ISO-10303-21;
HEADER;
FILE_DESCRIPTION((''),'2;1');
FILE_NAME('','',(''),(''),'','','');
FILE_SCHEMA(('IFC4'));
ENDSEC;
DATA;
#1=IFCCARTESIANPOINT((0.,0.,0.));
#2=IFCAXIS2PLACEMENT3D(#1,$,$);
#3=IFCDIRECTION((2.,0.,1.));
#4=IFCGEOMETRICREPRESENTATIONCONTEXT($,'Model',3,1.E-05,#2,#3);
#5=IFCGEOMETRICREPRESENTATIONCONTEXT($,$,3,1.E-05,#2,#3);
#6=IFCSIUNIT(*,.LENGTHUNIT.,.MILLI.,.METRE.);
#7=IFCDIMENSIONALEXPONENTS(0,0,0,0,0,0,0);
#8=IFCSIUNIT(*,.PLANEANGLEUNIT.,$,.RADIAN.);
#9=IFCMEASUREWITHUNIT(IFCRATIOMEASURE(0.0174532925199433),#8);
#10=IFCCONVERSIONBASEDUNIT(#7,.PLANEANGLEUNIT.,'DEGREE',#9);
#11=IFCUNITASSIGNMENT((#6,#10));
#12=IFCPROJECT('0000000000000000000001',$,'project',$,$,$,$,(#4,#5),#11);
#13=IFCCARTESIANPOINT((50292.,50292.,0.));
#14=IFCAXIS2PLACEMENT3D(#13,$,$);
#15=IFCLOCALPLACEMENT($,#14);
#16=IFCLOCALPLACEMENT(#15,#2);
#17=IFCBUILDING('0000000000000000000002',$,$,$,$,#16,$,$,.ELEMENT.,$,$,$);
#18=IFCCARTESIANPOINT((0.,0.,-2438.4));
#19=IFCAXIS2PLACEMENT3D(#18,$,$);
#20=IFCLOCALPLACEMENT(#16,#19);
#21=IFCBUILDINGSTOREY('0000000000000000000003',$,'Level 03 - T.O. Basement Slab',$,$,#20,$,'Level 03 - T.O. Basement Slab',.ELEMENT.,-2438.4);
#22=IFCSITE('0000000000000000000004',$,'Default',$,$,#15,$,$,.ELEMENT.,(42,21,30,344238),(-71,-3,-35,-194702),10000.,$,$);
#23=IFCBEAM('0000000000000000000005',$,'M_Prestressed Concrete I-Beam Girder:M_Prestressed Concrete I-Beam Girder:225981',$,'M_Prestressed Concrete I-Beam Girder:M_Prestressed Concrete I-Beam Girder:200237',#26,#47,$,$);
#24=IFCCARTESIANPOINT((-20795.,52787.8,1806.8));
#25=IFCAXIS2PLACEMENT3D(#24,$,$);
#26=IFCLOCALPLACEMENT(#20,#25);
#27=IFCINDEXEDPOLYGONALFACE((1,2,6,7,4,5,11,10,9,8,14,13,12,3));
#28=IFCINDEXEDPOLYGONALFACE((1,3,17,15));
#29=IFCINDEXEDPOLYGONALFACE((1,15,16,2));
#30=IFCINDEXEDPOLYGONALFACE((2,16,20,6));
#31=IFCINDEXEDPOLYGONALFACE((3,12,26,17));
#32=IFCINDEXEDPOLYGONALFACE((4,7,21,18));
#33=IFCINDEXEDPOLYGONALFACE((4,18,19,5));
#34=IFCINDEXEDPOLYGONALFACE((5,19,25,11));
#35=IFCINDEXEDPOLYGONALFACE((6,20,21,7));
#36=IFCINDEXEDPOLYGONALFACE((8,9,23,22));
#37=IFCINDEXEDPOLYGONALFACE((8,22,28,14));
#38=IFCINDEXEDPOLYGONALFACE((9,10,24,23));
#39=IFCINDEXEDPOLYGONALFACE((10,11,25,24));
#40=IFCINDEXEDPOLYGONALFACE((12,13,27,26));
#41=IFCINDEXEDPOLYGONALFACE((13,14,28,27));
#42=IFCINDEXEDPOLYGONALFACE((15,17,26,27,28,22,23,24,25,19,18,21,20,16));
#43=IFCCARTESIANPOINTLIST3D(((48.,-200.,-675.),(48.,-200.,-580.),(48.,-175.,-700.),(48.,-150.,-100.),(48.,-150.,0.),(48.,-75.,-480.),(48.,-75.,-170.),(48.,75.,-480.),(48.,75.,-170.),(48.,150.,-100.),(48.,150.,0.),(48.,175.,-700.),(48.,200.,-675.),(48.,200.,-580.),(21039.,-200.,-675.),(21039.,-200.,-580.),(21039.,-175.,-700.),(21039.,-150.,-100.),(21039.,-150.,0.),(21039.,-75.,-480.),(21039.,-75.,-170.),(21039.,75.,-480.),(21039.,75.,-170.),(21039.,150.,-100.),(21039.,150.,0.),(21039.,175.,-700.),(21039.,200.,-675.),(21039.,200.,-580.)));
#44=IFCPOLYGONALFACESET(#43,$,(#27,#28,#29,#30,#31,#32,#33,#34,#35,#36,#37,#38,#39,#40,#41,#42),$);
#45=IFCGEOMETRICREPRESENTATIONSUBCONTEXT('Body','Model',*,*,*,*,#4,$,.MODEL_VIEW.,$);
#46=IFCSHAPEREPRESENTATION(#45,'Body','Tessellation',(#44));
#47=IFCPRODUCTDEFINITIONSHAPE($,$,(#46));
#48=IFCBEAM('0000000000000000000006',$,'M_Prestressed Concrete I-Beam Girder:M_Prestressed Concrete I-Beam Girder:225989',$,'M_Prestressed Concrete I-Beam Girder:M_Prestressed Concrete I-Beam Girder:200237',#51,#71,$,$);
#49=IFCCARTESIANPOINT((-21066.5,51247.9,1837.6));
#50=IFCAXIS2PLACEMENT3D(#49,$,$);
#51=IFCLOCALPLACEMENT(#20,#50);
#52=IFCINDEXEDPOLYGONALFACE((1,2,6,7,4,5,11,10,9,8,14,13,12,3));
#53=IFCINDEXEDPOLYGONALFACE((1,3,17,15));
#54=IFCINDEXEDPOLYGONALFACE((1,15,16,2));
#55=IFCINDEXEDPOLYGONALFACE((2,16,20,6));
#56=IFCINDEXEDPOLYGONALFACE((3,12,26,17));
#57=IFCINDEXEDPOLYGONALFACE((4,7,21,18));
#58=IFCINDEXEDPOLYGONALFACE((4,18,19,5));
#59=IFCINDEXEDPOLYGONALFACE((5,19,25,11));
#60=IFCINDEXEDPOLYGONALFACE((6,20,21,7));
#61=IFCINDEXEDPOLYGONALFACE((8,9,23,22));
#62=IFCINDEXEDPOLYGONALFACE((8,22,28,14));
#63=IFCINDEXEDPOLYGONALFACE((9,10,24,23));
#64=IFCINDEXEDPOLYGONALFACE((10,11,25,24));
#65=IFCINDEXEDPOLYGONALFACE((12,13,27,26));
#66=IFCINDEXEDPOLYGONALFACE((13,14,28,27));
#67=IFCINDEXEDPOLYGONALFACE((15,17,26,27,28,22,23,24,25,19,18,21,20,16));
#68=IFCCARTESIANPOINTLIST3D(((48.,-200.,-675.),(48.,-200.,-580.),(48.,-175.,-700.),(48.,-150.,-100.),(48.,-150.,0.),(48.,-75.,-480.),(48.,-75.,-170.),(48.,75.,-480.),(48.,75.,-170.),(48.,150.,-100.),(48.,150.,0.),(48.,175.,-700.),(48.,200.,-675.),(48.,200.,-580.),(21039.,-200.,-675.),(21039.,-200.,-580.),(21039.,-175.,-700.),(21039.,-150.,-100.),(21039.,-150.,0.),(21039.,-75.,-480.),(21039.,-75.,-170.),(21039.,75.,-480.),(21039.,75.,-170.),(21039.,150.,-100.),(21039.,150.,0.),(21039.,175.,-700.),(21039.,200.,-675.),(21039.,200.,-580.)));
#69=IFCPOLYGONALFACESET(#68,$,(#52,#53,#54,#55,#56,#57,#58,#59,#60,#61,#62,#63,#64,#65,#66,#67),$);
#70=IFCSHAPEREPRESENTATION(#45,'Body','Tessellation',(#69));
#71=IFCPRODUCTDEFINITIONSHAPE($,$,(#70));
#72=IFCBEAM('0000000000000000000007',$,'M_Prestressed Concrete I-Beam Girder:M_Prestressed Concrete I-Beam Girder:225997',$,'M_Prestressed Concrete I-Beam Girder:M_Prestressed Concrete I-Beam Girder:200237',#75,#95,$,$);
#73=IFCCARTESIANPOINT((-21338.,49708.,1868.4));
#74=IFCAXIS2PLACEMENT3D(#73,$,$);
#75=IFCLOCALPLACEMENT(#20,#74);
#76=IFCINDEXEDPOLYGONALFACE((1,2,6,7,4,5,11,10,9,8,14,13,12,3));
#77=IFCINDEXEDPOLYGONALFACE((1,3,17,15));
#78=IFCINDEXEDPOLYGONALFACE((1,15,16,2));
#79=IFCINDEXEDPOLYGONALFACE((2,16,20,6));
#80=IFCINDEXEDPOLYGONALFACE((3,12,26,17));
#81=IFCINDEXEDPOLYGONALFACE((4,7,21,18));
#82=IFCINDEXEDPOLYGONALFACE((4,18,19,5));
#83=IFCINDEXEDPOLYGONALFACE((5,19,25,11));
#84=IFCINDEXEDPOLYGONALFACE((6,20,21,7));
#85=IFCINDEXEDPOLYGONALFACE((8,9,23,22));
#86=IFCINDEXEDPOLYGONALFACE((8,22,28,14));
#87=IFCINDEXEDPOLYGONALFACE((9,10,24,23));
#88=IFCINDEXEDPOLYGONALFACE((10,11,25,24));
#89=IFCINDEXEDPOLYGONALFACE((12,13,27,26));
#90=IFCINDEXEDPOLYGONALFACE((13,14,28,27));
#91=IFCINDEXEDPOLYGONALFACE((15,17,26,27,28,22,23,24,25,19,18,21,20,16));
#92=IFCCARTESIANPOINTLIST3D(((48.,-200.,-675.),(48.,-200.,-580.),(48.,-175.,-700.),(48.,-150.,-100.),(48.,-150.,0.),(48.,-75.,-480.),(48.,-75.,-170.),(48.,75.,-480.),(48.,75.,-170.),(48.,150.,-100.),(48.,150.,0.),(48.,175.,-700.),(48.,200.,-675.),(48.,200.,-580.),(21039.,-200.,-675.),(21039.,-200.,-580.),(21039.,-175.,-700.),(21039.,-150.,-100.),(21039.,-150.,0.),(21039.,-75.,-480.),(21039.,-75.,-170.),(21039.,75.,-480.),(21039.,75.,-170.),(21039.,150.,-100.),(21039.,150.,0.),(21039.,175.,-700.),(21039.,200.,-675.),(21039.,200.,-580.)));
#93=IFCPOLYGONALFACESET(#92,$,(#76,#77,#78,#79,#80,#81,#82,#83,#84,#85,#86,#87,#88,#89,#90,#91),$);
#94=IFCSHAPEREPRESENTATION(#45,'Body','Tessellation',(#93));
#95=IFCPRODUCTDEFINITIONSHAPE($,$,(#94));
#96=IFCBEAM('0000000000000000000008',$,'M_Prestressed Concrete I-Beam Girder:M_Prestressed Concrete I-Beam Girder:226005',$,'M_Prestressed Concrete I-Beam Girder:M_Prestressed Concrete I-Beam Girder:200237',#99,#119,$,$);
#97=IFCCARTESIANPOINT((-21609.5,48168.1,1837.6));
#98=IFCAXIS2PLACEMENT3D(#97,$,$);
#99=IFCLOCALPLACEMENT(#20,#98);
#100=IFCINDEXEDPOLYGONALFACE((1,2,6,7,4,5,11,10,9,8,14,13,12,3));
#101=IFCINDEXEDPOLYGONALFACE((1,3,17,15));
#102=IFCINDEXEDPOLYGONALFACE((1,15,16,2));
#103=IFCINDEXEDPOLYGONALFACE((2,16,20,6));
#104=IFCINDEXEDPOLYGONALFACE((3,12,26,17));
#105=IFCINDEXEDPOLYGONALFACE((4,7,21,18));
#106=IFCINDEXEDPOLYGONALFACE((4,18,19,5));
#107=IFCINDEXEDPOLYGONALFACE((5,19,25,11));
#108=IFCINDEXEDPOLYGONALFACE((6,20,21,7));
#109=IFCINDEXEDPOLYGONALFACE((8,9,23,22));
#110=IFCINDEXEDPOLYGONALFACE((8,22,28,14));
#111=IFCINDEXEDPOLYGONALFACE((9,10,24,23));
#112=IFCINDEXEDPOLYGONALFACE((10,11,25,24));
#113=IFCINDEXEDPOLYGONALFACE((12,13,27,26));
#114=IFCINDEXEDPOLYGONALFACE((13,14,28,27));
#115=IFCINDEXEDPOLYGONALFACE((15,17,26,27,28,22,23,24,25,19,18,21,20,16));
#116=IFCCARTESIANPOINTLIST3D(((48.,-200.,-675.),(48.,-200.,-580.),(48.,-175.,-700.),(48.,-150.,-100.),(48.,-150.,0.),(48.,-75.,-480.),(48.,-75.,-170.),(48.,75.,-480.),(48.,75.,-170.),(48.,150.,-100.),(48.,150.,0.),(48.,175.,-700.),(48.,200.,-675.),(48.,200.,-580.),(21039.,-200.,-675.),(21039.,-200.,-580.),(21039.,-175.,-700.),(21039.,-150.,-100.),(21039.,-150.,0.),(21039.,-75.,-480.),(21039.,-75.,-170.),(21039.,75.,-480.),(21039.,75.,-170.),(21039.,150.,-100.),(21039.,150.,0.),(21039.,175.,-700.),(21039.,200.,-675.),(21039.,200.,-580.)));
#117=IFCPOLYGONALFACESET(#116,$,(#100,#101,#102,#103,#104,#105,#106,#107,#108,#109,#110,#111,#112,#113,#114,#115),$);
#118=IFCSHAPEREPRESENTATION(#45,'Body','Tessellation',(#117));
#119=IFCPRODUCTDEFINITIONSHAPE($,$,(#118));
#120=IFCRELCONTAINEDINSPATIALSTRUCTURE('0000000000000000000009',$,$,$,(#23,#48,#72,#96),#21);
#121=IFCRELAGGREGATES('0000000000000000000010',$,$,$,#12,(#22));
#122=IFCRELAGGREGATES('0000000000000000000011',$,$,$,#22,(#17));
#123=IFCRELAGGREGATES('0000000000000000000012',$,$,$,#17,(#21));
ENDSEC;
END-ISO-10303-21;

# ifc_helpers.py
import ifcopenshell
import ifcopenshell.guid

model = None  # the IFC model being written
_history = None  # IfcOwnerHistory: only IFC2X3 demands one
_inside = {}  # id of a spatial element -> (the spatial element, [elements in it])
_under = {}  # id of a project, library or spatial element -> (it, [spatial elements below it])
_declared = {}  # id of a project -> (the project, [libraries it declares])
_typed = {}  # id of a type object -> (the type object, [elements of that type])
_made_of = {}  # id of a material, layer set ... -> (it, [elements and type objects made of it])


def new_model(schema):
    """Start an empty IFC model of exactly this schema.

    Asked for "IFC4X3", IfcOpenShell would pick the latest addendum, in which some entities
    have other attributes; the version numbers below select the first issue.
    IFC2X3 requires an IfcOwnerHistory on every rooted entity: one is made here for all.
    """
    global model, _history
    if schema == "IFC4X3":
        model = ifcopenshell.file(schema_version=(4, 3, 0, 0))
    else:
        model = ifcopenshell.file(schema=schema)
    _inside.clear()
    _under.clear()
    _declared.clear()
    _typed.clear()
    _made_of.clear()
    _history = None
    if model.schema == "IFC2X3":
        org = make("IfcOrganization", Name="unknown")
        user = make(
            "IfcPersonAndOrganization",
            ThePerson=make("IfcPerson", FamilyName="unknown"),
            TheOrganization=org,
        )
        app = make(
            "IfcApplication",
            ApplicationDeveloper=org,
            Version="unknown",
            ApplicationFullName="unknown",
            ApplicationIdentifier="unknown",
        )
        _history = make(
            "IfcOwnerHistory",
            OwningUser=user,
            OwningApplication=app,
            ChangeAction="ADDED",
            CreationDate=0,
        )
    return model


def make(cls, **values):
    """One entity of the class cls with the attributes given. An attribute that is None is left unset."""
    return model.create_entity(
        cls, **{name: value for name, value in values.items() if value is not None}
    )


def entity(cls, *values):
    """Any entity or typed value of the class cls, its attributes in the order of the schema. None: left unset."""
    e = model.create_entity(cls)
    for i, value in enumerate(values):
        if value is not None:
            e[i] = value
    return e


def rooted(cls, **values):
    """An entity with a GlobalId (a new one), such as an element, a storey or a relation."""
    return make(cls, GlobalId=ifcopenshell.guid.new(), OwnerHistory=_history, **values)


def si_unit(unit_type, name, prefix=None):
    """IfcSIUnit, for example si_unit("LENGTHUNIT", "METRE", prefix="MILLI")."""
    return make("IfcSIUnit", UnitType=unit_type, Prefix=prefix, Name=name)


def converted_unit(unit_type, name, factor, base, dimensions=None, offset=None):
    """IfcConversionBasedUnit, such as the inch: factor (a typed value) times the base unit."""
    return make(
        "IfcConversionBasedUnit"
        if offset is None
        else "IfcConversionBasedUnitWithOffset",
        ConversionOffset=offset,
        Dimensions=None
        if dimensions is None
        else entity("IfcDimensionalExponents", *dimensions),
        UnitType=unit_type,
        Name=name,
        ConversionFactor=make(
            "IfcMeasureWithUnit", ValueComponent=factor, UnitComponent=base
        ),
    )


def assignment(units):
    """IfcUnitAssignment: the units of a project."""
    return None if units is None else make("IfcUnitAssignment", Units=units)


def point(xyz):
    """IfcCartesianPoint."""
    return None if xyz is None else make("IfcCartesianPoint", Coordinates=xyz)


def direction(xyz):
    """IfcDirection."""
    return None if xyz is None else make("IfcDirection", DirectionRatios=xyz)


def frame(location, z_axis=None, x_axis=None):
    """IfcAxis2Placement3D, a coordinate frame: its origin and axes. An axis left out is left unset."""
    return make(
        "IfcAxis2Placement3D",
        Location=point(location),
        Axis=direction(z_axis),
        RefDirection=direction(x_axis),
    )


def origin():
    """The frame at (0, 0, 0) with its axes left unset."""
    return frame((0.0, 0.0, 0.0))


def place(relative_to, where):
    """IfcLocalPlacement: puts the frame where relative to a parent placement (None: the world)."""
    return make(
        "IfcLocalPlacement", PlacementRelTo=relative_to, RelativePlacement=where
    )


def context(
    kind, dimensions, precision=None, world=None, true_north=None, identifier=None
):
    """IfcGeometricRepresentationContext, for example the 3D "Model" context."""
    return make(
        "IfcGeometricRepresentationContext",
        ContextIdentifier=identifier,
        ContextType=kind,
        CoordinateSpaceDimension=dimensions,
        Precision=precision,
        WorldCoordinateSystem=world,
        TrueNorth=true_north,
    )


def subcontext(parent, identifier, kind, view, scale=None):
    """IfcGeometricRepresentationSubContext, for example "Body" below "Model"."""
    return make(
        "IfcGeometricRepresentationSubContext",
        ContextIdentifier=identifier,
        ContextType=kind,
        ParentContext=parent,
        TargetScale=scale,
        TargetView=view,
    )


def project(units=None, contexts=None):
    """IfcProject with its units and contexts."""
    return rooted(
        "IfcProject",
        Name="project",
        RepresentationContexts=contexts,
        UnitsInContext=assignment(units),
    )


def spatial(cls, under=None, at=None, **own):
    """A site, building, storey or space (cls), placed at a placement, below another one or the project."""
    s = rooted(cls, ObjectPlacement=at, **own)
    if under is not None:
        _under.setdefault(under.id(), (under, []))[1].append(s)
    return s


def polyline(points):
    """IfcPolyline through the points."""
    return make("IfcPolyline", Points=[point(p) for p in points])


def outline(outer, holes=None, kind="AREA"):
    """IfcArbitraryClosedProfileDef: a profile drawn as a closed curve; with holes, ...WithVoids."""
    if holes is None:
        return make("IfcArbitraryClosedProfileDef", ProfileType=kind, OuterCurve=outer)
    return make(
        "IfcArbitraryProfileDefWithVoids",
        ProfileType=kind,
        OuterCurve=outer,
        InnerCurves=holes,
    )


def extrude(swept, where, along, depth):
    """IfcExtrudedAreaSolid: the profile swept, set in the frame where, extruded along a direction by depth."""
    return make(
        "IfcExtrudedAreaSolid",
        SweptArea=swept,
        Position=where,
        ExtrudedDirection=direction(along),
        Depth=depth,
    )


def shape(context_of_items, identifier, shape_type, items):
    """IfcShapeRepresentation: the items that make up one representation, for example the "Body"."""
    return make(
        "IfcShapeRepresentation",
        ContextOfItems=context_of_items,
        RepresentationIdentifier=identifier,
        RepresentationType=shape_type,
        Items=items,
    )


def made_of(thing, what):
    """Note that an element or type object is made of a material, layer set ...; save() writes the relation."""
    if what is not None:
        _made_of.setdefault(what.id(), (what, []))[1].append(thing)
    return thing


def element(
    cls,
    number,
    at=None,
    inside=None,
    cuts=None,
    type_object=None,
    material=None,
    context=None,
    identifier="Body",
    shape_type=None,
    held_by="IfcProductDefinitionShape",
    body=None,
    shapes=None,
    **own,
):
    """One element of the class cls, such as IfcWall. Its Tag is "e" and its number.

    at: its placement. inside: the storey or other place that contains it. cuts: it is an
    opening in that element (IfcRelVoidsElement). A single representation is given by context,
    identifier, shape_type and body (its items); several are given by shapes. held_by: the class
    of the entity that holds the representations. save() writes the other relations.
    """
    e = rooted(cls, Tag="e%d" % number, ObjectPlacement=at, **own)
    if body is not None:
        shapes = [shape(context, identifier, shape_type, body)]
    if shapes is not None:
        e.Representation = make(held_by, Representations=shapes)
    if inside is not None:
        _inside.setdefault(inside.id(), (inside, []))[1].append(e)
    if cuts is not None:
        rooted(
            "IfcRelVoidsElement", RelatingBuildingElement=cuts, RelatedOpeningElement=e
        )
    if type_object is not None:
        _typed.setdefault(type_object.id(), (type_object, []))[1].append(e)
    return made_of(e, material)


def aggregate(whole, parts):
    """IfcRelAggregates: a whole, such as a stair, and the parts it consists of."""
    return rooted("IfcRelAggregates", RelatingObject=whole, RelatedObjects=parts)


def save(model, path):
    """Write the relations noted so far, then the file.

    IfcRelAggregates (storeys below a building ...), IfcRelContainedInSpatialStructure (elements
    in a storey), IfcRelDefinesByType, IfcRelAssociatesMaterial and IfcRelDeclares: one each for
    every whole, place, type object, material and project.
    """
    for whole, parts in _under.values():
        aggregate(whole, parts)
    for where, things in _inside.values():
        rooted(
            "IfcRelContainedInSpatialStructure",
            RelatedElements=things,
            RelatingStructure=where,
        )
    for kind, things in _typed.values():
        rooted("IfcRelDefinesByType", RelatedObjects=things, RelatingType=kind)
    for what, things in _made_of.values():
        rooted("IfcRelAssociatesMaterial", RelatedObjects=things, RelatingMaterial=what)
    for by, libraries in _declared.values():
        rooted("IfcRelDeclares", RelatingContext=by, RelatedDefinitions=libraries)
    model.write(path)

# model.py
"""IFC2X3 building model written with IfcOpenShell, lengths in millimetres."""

from ifc_helpers import new_model, entity, si_unit, converted_unit, direction, frame, origin, place, context, subcontext, project, spatial, polyline, outline, extrude, element, save


model = new_model("IFC2X3")

# Units and contexts
model_context = context("Model", 3, precision=1e-05, world=origin(), true_north=direction((2.0, 0.0, 1.0)))
context_of_model = context(None, 3, precision=1e-05, world=origin(), true_north=direction((2.0, 0.0, 1.0)))
body_context = subcontext(model_context, "Body", "Model", "MODEL_VIEW")
ifc_project = project(units=[si_unit("LENGTHUNIT", "METRE", prefix="MILLI"), converted_unit("PLANEANGLEUNIT", "DEGREE", entity("IfcRatioMeasure", 0.0174532925199433), si_unit("PLANEANGLEUNIT", "RADIAN"), dimensions=[0, 0, 0, 0, 0, 0, 0])], contexts=[model_context, context_of_model])

# Site, building, storey
site_placement = place(None, frame((50292.0, 50292.0, 0.0)))
site = spatial("IfcSite", under=ifc_project, at=site_placement, Name="Default", CompositionType="ELEMENT", RefLatitude=(42, 21, 30, 344238), RefLongitude=(-71, -3, -35, -194702), RefElevation=10000.0)
building_placement = place(site_placement, origin())
building = spatial("IfcBuilding", under=site, at=building_placement, CompositionType="ELEMENT")
storey_placement = place(building_placement, frame((0.0, 0.0, -2438.4)))
storey = spatial("IfcBuildingStorey", under=building, at=storey_placement, Name="Level 03 - T.O. Basement Slab", LongName="Level 03 - T.O. Basement Slab", CompositionType="ELEMENT", Elevation=-2438.4)

# Beams
beam_1_placement = place(storey_placement, frame((-20795.0, 52787.8, 1806.8)))
element("IfcBeam", 1, at=beam_1_placement, inside=storey, Name="M_Prestressed Concrete I-Beam Girder:M_Prestressed Concrete I-Beam Girder:225981", ObjectType="M_Prestressed Concrete I-Beam Girder:M_Prestressed Concrete I-Beam Girder:200237", context=body_context, shape_type="SweptSolid", body=[
    extrude(outline(polyline([(193.6, -200.0), (288.6, -200.0), (313.6, -175.0), (313.6, 175.0), (288.6, 200.0), (193.6, 200.0), (93.6, 75.0), (-216.4, 75.0), (-286.4, 150.0), (-386.4, 150.0), (-386.4, -150.0), (-286.4, -150.0), (-216.4, -75.0), (93.6, -75.0), (193.6, -200.0)])), frame((48.0, 0.0, -386.4), z_axis=(1.0, 0.0, 0.0), x_axis=(0.0, 0.0, -1.0)), (0.0, 0.0, 1.0), 20991.0),
])
beam_2_placement = place(storey_placement, frame((-21066.5, 51247.9, 1837.6)))
element("IfcBeam", 2, at=beam_2_placement, inside=storey, Name="M_Prestressed Concrete I-Beam Girder:M_Prestressed Concrete I-Beam Girder:225989", ObjectType="M_Prestressed Concrete I-Beam Girder:M_Prestressed Concrete I-Beam Girder:200237", context=body_context, shape_type="SweptSolid", body=[
    extrude(outline(polyline([(193.6, -200.0), (288.6, -200.0), (313.6, -175.0), (313.6, 175.0), (288.6, 200.0), (193.6, 200.0), (93.6, 75.0), (-216.4, 75.0), (-286.4, 150.0), (-386.4, 150.0), (-386.4, -150.0), (-286.4, -150.0), (-216.4, -75.0), (93.6, -75.0), (193.6, -200.0)])), frame((48.0, 0.0, -386.4), z_axis=(1.0, 0.0, 0.0), x_axis=(0.0, 0.0, -1.0)), (0.0, 0.0, 1.0), 20991.0),
])
beam_3_placement = place(storey_placement, frame((-21338.0, 49708.0, 1868.4)))
element("IfcBeam", 3, at=beam_3_placement, inside=storey, Name="M_Prestressed Concrete I-Beam Girder:M_Prestressed Concrete I-Beam Girder:225997", ObjectType="M_Prestressed Concrete I-Beam Girder:M_Prestressed Concrete I-Beam Girder:200237", context=body_context, shape_type="SweptSolid", body=[
    extrude(outline(polyline([(193.6, -200.0), (288.6, -200.0), (313.6, -175.0), (313.6, 175.0), (288.6, 200.0), (193.6, 200.0), (93.6, 75.0), (-216.4, 75.0), (-286.4, 150.0), (-386.4, 150.0), (-386.4, -150.0), (-286.4, -150.0), (-216.4, -75.0), (93.6, -75.0), (193.6, -200.0)])), frame((48.0, 0.0, -386.4), z_axis=(1.0, 0.0, 0.0), x_axis=(0.0, 0.0, -1.0)), (0.0, 0.0, 1.0), 20991.0),
])
beam_4_placement = place(storey_placement, frame((-21609.5, 48168.1, 1837.6)))
element("IfcBeam", 4, at=beam_4_placement, inside=storey, Name="M_Prestressed Concrete I-Beam Girder:M_Prestressed Concrete I-Beam Girder:226005", ObjectType="M_Prestressed Concrete I-Beam Girder:M_Prestressed Concrete I-Beam Girder:200237", context=body_context, shape_type="SweptSolid", body=[
    extrude(outline(polyline([(193.6, -200.0), (288.6, -200.0), (313.6, -175.0), (313.6, 175.0), (288.6, 200.0), (193.6, 200.0), (93.6, 75.0), (-216.4, 75.0), (-286.4, 150.0), (-386.4, 150.0), (-386.4, -150.0), (-286.4, -150.0), (-216.4, -75.0), (93.6, -75.0), (193.6, -200.0)])), frame((48.0, 0.0, -386.4), z_axis=(1.0, 0.0, 0.0), x_axis=(0.0, 0.0, -1.0)), (0.0, 0.0, 1.0), 20991.0),
])

save(model, "model.ifc")
